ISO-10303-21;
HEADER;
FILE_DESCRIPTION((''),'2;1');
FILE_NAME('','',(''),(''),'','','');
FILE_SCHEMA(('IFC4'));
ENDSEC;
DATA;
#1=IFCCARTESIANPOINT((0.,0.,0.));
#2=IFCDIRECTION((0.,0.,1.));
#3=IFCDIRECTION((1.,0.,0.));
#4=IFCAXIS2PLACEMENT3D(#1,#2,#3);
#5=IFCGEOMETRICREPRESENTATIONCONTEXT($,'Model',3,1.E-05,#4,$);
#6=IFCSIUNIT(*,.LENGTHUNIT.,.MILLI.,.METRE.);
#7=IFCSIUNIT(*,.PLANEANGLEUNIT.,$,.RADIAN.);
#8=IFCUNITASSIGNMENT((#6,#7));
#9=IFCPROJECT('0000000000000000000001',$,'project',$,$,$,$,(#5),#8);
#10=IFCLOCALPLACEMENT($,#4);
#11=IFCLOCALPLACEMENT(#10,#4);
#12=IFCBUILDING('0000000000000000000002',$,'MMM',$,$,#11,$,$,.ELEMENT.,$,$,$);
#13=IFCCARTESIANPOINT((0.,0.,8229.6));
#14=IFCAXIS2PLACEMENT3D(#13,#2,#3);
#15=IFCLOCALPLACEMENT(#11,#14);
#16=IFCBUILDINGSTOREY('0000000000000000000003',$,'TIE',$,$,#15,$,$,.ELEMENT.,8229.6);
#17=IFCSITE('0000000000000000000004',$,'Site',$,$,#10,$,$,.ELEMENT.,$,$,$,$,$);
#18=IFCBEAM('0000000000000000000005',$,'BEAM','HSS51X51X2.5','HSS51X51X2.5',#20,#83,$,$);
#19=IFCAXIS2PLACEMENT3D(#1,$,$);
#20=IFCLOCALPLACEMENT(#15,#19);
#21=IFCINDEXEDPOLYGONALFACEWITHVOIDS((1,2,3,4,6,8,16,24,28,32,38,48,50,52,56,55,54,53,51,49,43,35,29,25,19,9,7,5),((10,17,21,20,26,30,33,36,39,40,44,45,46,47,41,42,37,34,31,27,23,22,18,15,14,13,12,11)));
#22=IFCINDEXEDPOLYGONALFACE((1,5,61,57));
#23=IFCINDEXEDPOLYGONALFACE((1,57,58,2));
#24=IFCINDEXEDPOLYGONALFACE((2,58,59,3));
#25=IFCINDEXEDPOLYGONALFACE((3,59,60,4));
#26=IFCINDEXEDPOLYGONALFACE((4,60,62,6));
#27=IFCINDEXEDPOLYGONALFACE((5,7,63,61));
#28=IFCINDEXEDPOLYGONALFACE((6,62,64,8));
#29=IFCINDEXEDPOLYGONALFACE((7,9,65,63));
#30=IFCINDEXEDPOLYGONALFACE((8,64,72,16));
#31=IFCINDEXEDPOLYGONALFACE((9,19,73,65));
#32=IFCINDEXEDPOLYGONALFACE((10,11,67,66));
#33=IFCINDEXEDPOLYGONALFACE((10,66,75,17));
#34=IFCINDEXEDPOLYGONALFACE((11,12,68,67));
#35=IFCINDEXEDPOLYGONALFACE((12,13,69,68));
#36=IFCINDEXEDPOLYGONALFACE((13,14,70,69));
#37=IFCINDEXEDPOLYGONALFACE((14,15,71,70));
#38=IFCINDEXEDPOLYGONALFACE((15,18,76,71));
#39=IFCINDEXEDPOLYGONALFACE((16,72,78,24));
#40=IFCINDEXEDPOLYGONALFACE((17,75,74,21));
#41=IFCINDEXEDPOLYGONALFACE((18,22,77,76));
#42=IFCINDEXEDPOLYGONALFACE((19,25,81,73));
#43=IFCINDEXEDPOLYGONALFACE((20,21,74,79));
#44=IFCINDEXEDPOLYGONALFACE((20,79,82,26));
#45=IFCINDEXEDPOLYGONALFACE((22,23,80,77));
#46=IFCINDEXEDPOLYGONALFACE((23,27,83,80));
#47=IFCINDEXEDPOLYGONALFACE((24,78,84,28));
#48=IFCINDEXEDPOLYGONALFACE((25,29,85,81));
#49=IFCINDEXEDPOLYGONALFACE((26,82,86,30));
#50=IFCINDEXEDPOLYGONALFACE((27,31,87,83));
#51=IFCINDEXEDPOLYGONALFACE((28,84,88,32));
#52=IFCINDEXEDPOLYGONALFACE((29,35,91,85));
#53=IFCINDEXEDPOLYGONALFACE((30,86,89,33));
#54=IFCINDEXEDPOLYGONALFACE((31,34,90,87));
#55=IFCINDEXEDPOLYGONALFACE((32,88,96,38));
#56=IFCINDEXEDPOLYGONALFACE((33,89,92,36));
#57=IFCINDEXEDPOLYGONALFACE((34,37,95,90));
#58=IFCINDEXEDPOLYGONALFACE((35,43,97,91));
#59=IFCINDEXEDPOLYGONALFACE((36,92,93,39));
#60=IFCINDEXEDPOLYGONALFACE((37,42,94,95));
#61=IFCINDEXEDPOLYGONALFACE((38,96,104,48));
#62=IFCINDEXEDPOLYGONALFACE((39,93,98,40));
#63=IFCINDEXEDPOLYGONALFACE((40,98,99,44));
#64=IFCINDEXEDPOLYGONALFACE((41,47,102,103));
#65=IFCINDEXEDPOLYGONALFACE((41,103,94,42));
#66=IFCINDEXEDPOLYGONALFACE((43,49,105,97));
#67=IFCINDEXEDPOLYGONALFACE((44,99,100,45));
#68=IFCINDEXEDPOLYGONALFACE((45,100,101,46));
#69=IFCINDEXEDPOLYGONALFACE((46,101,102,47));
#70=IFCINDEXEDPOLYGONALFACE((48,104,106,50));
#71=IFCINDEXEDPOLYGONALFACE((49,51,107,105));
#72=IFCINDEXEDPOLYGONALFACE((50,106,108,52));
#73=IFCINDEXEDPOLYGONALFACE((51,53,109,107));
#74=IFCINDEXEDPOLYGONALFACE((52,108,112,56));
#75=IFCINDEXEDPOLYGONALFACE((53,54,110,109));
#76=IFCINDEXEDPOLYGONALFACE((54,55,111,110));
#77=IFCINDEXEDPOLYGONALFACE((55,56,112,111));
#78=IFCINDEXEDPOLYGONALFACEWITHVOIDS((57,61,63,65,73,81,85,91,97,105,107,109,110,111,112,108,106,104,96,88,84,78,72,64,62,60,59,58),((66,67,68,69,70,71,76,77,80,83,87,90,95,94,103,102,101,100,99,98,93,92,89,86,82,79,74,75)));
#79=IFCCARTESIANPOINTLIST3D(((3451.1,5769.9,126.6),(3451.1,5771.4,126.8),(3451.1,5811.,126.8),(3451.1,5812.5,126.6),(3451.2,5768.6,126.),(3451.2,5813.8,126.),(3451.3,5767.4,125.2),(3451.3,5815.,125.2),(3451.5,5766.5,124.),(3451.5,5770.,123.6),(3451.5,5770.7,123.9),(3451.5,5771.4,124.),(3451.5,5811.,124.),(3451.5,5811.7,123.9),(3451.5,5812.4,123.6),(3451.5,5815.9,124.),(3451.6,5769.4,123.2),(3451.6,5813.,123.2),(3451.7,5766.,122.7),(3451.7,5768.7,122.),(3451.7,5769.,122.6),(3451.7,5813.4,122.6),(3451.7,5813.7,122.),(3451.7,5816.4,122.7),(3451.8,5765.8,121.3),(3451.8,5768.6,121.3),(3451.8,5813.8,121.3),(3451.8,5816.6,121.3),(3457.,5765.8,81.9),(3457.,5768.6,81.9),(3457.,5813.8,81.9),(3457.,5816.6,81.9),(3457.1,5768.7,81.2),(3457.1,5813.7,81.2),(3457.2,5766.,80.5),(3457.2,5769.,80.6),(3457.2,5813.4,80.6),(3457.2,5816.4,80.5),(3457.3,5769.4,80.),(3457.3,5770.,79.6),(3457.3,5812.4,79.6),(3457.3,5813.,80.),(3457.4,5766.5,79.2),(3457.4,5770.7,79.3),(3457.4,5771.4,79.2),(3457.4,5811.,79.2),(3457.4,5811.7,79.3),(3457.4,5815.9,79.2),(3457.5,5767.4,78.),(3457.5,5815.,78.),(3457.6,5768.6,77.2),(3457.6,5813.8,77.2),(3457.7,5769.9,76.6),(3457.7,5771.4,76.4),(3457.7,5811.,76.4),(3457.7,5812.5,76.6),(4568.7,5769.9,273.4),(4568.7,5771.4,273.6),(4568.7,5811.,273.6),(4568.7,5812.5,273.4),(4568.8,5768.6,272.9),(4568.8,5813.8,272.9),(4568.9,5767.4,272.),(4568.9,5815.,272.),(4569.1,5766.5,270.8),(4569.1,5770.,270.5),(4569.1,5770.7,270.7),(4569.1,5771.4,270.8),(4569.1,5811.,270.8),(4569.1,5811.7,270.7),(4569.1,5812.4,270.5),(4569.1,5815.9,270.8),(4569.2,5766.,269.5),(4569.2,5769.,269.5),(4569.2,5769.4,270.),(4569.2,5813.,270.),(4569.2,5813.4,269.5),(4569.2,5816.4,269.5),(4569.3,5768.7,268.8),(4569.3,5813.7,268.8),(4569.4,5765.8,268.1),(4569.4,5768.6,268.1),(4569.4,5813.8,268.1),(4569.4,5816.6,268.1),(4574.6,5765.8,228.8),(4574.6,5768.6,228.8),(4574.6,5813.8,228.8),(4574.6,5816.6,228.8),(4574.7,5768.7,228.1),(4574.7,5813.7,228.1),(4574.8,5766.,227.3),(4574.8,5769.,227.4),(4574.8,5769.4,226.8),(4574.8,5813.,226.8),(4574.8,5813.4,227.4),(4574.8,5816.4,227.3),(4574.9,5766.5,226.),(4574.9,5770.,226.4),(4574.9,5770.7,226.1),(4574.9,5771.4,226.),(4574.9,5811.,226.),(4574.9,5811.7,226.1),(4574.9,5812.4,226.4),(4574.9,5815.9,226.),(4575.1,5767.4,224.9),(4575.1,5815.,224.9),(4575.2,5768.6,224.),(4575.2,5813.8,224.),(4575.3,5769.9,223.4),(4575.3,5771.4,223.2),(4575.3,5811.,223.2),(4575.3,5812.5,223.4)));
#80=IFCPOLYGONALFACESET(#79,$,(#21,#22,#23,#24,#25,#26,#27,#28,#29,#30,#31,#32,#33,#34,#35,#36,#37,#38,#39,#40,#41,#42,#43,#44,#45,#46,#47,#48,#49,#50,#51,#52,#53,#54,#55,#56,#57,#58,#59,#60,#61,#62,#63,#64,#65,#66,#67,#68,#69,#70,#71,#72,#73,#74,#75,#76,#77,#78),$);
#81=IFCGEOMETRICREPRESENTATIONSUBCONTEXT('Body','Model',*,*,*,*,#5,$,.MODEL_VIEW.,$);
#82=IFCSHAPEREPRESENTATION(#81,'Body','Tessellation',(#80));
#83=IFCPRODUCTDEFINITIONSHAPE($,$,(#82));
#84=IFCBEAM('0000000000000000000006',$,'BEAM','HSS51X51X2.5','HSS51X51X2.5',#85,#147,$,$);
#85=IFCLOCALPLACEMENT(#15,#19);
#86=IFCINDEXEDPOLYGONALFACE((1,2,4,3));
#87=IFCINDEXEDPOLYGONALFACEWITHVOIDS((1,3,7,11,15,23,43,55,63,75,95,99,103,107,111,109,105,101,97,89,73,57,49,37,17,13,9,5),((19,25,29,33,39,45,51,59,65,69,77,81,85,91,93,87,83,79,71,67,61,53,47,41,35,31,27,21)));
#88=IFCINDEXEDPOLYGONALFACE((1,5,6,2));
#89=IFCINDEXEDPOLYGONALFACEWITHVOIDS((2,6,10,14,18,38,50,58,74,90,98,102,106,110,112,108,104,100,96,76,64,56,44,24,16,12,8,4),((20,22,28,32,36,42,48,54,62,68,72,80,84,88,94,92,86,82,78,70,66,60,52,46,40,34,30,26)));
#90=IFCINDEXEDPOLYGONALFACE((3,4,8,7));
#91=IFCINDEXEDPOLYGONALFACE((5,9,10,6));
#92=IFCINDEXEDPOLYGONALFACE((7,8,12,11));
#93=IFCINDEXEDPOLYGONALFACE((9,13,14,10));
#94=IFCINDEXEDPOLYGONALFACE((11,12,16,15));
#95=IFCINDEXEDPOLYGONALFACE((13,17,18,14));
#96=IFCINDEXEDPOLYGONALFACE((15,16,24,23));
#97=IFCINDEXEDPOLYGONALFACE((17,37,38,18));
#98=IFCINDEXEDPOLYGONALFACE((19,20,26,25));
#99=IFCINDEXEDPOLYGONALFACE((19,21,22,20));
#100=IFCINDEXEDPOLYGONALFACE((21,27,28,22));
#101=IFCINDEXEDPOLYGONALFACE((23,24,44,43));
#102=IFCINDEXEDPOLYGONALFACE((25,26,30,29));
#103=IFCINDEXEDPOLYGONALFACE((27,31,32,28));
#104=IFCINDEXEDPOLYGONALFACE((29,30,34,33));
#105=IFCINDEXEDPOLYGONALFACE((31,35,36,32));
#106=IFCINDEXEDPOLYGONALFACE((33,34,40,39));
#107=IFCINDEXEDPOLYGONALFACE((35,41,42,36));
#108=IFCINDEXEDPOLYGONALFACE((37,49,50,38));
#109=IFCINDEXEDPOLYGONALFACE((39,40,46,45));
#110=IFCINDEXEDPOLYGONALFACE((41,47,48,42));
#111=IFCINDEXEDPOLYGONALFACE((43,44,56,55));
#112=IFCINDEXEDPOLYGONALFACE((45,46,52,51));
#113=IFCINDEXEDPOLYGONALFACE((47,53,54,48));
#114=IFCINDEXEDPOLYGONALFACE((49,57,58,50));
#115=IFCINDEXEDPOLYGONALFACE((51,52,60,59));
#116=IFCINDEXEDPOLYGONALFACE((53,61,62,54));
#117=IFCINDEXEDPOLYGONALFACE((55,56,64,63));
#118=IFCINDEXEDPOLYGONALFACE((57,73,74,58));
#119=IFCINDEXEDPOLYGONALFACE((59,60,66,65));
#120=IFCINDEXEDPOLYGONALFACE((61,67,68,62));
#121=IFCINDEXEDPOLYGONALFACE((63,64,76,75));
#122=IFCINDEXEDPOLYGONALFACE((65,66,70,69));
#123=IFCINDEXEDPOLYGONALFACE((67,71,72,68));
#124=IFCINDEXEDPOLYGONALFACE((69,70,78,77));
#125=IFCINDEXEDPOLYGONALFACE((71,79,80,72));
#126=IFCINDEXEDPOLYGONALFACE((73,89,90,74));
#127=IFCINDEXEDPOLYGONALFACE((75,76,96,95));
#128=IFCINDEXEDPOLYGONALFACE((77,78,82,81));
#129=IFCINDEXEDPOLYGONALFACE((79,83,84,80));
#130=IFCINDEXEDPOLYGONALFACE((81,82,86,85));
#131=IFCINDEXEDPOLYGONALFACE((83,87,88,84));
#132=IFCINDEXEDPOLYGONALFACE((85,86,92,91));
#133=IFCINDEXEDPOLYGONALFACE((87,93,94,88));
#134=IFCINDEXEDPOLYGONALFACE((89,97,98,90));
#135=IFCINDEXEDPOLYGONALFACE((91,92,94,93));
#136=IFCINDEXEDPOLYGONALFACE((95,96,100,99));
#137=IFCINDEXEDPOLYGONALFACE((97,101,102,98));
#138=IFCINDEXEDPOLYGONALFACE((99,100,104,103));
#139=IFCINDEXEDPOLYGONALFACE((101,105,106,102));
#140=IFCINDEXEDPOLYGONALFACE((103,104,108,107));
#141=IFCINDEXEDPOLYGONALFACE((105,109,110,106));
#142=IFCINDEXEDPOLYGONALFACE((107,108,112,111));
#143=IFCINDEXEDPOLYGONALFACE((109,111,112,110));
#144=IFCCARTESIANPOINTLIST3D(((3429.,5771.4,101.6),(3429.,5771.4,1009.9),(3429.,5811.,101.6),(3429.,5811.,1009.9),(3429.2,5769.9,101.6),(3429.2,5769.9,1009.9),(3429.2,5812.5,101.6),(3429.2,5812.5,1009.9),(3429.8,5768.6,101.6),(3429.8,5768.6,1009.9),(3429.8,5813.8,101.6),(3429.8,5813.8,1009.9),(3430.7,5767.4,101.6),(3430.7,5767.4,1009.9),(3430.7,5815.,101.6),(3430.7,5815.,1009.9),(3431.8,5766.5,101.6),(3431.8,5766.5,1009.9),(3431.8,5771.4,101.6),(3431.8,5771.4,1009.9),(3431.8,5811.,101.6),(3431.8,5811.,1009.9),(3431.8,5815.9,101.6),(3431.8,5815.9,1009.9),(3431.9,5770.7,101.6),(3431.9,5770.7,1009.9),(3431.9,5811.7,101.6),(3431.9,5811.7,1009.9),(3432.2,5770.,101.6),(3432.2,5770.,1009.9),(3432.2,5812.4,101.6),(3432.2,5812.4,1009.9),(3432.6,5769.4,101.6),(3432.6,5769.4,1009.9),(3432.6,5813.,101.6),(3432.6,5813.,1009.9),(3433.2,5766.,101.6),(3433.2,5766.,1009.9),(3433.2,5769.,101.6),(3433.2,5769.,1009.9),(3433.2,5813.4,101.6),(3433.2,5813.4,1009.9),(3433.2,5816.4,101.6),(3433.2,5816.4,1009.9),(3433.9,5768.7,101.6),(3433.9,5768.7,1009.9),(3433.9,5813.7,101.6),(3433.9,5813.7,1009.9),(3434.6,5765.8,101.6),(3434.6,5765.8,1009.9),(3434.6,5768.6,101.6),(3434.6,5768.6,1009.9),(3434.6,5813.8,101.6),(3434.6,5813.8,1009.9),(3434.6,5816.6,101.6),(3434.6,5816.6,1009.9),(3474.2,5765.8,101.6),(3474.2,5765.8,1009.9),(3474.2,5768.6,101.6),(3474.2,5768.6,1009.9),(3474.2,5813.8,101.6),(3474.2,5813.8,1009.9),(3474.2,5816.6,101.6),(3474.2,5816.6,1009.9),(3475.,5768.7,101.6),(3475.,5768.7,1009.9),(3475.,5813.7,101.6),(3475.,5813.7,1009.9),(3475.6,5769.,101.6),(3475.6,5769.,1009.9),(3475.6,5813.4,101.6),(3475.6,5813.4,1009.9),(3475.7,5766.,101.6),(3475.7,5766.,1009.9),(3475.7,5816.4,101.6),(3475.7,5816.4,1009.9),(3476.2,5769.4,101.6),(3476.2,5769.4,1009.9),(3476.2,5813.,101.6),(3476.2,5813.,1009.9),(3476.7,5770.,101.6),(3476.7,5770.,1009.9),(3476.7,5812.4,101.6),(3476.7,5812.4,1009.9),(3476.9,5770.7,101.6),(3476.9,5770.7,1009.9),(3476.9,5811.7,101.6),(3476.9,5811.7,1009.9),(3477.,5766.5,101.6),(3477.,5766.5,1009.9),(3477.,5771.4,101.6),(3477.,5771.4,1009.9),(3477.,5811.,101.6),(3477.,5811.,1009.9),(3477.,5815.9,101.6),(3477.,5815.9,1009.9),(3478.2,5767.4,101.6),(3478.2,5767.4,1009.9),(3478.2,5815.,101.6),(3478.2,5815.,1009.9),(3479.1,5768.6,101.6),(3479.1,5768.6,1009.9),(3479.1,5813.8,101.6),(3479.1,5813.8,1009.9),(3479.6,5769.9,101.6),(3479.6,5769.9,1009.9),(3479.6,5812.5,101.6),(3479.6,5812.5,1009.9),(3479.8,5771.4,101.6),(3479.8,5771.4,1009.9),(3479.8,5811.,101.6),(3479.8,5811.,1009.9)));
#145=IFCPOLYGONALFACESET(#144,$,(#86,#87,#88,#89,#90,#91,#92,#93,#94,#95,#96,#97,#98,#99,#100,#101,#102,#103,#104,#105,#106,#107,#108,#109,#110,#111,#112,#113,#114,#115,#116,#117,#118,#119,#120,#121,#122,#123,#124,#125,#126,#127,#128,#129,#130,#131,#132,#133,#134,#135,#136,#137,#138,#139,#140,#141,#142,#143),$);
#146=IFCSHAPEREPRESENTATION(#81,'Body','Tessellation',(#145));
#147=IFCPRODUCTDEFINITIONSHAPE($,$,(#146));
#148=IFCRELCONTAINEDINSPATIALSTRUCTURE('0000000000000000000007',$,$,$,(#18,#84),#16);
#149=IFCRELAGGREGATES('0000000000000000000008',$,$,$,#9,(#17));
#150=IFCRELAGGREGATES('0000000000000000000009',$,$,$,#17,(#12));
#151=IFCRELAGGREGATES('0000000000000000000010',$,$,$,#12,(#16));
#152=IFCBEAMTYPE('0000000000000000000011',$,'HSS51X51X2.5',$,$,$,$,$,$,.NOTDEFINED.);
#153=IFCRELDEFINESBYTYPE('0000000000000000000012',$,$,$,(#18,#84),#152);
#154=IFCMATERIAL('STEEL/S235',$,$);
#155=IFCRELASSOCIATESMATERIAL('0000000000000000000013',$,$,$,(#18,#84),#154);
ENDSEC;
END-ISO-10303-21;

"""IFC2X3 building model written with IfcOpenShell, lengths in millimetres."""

from ifc_helpers import new_model, si_unit, frame, origin_with_axes, origin_2d_with_axis, place, context, subcontext, project, spatial, hollow_rectangle, extrude, material, type_object, element, save


model = new_model("IFC2X3")

# Units and contexts
model_context = context("Model", 3, precision=1e-05, world=origin_with_axes())
body_context = subcontext(model_context, "Body", "Model", "MODEL_VIEW")
ifc_project = project(units=[si_unit("LENGTHUNIT", "METRE", prefix="MILLI"), si_unit("PLANEANGLEUNIT", "RADIAN")], contexts=[model_context])

# Site, building, storey
site_placement = place(None, origin_with_axes())
site = spatial("IfcSite", under=ifc_project, at=site_placement, Name="Site", CompositionType="ELEMENT")
building_placement = place(site_placement, origin_with_axes())
building = spatial("IfcBuilding", under=site, at=building_placement, Name="MMM", CompositionType="ELEMENT")
storey_placement = place(building_placement, frame((0.0, 0.0, 8229.6), z_axis=(0.0, 0.0, 1.0), x_axis=(1.0, 0.0, 0.0)))
storey = spatial("IfcBuildingStorey", under=building, at=storey_placement, Name="TIE", CompositionType="ELEMENT", Elevation=8229.6)

# Beams
ifc_material = material(Name="STEEL/S235")
beam_type_1 = type_object("IfcBeamType", Name="HSS51X51X2.5", PredefinedType="NOTDEFINED")
beam_1_placement = place(storey_placement, frame((3454.4, 5791.2, 101.6), z_axis=(-0.130258, 0.0, 0.99148), x_axis=(0.99148, 0.0, 0.130258)))
element("IfcBeam", 1, at=beam_1_placement, inside=storey, type_object=beam_type_1, material=ifc_material, Name="BEAM", Description="HSS51X51X2.5", ObjectType="HSS51X51X2.5", context=body_context, shape_type="SweptSolid", body=[
    extrude(hollow_rectangle(XDim=50.8, YDim=50.8, WallThickness=2.8, InnerFilletRadius=2.8, OuterFilletRadius=5.6, at=origin_2d_with_axis()), frame((1127.2, 0.0, 0.0), z_axis=(-1.0, 0.0, 0.0), x_axis=(0.0, -1.0, 0.0)), (0.0, 0.0, 1.0), 1127.2),
])
beam_2_placement = place(storey_placement, frame((3454.4, 5791.2, 1009.9), z_axis=(-1.0, 0.0, 0.0), x_axis=(0.0, 0.0, -1.0)))
element("IfcBeam", 2, at=beam_2_placement, inside=storey, type_object=beam_type_1, material=ifc_material, Name="BEAM", Description="HSS51X51X2.5", ObjectType="HSS51X51X2.5", context=body_context, shape_type="SweptSolid", body=[
    extrude(hollow_rectangle(XDim=50.8, YDim=50.8, WallThickness=2.8, InnerFilletRadius=2.8, OuterFilletRadius=5.6, at=origin_2d_with_axis()), frame((908.3, 0.0, 0.0), z_axis=(-1.0, 0.0, 0.0), x_axis=(0.0, -1.0, 0.0)), (0.0, 0.0, 1.0), 908.3),
])

save(model, "model.ifc")
